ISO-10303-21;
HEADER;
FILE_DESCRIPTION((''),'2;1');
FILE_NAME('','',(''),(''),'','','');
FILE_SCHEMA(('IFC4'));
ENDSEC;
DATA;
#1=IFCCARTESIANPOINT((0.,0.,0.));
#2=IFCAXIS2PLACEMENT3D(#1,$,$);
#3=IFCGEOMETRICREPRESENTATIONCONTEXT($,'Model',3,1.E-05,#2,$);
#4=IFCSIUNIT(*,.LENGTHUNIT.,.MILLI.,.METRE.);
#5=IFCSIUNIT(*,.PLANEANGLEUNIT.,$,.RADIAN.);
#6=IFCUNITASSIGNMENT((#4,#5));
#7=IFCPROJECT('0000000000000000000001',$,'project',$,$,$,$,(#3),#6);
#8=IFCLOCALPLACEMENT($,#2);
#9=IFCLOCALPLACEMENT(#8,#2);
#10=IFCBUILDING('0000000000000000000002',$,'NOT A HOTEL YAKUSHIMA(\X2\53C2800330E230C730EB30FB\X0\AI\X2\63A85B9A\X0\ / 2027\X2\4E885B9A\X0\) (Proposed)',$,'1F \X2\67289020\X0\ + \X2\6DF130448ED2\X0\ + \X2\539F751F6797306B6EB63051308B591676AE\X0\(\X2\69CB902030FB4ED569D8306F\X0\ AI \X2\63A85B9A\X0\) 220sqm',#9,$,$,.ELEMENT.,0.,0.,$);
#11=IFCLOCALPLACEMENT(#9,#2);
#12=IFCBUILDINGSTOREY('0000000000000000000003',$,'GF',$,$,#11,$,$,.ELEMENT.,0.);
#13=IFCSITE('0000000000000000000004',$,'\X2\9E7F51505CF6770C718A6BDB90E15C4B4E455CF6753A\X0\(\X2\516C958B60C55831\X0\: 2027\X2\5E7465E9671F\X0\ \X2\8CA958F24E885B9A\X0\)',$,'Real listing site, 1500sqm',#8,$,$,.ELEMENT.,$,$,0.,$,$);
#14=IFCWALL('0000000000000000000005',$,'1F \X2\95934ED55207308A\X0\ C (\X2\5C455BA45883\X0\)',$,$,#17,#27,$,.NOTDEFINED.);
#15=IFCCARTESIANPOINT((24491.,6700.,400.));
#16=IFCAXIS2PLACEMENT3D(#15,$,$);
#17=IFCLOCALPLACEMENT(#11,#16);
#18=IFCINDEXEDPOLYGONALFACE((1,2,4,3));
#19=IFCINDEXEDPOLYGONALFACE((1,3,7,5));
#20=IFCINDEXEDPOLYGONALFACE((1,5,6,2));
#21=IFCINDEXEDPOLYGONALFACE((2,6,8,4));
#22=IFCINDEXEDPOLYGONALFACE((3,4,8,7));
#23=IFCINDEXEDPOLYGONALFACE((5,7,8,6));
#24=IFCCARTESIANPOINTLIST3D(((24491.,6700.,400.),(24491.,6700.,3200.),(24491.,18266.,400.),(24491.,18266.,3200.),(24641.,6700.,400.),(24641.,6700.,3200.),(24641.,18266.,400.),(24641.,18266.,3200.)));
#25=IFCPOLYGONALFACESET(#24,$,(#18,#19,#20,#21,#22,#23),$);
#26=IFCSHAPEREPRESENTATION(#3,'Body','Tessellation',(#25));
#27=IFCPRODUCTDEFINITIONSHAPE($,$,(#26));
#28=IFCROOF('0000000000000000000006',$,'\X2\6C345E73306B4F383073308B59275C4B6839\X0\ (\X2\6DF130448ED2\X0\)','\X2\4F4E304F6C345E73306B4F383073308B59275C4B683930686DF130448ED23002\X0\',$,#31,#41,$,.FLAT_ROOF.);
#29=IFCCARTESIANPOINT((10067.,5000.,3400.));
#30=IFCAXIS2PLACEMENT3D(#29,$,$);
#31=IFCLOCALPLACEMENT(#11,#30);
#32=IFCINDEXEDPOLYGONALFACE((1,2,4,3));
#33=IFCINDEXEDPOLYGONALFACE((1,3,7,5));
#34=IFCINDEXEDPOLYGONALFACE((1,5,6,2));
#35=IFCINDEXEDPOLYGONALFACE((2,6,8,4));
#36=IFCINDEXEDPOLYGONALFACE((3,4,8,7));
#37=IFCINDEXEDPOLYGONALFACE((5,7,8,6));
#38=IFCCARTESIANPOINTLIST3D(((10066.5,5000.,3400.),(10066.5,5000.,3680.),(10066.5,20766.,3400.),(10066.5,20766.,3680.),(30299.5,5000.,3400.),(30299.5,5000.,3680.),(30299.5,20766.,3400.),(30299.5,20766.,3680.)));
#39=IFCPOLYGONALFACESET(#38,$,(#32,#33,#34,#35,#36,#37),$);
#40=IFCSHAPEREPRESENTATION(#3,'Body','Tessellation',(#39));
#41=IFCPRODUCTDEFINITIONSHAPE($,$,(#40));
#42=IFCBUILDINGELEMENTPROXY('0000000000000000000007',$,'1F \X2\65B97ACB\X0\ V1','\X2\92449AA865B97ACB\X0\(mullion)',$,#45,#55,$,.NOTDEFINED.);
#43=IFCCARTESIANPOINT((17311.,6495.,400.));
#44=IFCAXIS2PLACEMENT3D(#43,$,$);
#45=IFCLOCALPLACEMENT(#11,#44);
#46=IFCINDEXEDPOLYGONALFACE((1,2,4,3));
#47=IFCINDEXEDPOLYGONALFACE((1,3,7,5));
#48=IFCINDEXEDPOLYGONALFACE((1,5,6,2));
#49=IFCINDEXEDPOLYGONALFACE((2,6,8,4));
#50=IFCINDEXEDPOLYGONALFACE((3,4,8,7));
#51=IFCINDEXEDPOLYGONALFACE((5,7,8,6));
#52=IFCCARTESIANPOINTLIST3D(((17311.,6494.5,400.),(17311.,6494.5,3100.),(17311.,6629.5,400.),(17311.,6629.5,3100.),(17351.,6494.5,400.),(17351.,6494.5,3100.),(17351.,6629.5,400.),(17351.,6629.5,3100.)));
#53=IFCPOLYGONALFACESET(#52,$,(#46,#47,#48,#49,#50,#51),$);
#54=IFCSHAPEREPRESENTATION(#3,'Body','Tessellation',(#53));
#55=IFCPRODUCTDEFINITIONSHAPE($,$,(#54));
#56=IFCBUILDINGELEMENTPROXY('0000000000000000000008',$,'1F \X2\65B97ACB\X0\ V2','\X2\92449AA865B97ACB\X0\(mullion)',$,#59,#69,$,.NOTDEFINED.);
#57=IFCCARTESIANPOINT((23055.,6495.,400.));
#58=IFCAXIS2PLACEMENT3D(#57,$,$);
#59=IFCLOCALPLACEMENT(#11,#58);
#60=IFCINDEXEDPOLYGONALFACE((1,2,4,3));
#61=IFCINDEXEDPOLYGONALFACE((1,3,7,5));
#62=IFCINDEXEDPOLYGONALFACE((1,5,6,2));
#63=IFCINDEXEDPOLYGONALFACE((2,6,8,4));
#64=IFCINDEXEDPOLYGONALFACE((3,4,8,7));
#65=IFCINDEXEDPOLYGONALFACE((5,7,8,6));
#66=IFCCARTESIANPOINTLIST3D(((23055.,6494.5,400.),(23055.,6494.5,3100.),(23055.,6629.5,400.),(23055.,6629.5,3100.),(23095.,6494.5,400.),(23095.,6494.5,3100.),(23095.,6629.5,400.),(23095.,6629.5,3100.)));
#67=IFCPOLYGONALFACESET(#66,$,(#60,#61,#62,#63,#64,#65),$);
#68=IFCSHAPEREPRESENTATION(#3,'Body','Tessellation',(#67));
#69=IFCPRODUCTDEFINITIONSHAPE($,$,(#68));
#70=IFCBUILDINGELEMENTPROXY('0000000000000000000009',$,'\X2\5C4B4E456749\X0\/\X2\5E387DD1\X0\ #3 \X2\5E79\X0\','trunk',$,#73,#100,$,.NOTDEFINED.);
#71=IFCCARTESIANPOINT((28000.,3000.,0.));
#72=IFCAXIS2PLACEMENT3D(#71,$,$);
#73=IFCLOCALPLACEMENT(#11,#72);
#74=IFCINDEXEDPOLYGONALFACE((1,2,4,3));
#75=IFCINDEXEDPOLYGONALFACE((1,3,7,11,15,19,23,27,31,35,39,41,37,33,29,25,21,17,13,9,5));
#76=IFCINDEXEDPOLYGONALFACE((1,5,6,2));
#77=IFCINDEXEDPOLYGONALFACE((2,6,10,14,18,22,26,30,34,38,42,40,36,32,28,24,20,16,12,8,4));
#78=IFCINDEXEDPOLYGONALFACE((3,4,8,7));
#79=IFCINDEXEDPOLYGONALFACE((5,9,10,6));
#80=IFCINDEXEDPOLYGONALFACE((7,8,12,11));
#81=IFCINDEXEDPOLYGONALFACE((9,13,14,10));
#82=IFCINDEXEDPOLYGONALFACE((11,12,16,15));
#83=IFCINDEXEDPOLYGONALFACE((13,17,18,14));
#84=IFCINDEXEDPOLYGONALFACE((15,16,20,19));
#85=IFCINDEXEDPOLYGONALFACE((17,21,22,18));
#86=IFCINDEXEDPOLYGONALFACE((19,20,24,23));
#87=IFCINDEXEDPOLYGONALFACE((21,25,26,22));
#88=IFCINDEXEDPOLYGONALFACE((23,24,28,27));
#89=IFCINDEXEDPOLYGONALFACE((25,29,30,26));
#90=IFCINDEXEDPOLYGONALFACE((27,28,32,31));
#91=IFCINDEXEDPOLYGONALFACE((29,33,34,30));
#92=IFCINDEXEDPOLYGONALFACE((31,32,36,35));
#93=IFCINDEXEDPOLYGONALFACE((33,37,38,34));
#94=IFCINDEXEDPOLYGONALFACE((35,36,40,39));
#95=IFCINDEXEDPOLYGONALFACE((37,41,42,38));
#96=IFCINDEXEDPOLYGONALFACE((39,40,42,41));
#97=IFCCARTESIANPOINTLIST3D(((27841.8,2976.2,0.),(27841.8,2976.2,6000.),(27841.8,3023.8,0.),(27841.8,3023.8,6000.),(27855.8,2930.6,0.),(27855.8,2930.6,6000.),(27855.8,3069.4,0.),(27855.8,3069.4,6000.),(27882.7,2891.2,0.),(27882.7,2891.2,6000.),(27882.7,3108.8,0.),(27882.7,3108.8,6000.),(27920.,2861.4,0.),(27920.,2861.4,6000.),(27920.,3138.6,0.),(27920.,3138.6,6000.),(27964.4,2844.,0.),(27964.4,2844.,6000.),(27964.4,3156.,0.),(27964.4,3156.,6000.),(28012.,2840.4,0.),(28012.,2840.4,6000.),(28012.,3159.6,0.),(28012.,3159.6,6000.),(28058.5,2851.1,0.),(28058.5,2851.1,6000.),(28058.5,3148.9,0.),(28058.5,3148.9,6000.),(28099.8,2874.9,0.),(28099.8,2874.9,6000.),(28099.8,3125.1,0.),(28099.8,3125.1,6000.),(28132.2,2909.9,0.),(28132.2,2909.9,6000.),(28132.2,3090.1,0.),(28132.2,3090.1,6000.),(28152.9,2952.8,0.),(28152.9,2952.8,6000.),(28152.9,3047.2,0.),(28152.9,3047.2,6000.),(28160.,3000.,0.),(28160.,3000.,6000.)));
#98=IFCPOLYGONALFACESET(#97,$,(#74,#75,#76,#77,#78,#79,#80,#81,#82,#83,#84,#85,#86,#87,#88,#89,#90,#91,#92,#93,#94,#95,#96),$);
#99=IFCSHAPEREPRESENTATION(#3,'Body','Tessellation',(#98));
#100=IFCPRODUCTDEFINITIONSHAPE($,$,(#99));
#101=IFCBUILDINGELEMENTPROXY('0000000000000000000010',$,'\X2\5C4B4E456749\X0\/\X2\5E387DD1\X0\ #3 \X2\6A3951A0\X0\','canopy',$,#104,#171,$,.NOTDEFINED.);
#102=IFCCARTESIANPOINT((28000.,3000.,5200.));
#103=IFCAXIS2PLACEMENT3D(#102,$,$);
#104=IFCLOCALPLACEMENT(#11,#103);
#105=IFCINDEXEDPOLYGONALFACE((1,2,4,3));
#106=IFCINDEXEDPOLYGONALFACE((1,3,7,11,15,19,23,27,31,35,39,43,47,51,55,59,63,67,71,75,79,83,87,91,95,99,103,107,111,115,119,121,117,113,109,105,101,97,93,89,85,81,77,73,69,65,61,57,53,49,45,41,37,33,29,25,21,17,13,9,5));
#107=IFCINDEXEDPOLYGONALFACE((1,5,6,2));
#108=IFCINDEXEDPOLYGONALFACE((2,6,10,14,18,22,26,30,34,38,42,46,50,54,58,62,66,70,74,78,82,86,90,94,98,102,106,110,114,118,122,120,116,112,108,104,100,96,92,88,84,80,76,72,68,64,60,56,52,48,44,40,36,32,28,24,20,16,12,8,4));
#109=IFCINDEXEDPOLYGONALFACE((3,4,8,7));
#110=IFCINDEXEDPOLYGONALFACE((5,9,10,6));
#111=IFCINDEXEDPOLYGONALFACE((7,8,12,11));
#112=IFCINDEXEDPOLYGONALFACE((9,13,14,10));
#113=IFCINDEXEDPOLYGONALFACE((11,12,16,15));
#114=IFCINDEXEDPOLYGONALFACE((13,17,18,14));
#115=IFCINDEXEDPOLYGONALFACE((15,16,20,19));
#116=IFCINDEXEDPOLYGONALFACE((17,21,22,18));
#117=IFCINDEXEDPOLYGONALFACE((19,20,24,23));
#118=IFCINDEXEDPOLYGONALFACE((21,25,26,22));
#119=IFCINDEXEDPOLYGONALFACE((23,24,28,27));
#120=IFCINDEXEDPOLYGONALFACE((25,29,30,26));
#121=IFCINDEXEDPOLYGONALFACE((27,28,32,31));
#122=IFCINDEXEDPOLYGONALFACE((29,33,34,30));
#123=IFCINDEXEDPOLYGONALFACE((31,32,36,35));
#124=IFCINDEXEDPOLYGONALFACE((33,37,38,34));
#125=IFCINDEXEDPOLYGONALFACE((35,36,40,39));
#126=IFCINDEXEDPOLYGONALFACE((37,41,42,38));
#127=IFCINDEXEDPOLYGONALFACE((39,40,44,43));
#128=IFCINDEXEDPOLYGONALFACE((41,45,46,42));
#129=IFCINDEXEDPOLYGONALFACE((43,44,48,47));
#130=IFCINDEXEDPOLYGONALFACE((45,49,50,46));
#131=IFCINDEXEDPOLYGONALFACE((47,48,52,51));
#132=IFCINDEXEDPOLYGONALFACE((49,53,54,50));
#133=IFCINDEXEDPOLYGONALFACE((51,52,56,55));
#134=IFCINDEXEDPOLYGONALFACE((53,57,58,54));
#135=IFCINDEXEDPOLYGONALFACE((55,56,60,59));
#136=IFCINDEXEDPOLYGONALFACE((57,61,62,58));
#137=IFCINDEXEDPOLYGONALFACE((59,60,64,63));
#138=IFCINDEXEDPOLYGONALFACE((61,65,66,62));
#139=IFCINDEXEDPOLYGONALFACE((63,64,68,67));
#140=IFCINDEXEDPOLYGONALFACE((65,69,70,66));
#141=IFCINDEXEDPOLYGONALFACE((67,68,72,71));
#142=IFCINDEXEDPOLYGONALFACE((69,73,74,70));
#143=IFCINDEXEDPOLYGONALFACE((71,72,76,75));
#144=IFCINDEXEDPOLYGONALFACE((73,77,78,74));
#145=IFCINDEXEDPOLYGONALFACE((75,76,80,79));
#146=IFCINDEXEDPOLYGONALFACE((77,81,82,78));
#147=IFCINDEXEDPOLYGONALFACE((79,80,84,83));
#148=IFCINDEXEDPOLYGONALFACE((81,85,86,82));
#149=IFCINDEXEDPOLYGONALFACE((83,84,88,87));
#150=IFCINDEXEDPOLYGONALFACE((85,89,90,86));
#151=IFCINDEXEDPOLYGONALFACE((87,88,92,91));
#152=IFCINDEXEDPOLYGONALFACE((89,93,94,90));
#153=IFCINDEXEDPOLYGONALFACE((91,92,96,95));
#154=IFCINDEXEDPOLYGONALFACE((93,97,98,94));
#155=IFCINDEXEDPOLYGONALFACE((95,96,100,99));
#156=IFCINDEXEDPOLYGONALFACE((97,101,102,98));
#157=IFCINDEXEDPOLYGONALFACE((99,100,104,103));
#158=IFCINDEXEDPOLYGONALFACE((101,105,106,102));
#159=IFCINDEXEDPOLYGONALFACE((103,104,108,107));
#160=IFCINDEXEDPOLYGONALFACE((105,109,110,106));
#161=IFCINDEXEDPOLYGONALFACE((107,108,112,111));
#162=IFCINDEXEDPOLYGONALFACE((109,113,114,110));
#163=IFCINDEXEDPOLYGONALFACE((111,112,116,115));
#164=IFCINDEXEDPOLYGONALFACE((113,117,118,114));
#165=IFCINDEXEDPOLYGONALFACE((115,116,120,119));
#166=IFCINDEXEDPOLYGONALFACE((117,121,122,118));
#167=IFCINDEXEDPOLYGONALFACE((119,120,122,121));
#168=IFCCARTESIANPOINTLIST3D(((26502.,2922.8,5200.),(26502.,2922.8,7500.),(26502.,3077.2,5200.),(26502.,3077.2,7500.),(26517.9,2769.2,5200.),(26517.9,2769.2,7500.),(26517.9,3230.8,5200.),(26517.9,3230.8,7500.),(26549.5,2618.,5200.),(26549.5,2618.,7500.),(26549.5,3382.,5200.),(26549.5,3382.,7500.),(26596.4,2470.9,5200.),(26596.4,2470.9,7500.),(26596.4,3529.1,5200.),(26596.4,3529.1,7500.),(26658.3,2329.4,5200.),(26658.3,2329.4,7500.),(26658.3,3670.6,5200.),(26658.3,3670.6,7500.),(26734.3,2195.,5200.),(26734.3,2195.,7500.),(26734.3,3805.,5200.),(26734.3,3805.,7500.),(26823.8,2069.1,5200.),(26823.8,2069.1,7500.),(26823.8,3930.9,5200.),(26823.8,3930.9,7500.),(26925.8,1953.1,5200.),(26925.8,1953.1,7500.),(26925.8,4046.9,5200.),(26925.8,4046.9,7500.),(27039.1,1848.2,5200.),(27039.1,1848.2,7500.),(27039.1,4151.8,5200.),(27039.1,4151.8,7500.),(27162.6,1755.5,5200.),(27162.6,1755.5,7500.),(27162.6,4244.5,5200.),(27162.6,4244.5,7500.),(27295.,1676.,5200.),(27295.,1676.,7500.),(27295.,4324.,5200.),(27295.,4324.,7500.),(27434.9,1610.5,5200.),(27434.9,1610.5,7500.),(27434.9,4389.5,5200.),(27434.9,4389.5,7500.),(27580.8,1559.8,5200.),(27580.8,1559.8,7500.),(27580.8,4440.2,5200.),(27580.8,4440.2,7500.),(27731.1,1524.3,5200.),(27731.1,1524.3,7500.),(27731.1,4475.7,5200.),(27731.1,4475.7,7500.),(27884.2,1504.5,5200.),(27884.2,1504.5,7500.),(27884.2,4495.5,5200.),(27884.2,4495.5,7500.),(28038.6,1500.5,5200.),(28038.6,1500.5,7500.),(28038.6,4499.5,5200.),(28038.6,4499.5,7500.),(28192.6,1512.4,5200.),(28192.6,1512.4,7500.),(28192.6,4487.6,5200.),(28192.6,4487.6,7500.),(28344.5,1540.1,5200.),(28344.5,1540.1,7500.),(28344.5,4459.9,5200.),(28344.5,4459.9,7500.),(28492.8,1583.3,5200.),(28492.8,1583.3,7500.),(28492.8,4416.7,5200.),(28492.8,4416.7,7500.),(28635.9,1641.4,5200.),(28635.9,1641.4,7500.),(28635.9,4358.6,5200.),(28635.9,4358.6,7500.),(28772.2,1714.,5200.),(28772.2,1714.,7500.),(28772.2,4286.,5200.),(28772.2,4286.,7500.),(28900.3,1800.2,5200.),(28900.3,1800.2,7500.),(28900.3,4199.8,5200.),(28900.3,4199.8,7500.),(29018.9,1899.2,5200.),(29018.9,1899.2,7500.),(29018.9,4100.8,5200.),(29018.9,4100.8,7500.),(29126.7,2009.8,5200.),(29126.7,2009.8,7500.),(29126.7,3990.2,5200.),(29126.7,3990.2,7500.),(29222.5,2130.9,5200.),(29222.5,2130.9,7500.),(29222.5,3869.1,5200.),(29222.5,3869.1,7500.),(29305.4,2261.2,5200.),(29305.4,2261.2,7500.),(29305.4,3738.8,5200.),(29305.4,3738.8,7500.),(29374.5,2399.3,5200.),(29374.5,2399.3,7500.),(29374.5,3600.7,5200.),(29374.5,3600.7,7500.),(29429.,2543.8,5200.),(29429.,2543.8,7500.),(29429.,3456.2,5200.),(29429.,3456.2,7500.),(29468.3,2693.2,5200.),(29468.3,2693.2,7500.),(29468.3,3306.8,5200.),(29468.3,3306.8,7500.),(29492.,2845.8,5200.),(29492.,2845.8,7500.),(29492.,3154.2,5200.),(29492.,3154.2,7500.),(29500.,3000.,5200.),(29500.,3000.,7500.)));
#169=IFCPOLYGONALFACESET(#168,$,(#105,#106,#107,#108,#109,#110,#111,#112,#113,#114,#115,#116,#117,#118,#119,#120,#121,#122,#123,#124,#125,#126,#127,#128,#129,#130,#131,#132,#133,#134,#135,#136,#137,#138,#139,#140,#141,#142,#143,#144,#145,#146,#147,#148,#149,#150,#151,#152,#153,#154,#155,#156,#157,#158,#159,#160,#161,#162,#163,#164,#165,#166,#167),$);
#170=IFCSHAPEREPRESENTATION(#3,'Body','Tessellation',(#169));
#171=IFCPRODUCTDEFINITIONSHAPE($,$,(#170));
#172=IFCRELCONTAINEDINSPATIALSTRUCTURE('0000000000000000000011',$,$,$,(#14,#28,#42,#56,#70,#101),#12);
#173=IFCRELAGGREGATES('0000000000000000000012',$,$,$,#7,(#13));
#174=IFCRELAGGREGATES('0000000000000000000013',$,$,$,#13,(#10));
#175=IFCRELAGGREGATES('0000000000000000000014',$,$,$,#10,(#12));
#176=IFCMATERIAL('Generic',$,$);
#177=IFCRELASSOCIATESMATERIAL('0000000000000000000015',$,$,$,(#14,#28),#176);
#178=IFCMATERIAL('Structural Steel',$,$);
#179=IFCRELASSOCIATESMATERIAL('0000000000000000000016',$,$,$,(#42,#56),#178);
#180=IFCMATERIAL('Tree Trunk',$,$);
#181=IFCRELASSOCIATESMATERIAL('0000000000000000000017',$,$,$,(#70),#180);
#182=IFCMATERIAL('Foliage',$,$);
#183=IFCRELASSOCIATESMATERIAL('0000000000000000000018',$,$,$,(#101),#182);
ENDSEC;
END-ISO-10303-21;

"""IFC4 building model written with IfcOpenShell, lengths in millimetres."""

from ifc_helpers import new_model, si_unit, frame, frame_2d, origin, origin_2d, place, context, project, spatial, rectangle, circle, extrude, material, element, save


model = new_model("IFC4")

# Units and contexts
model_context = context("Model", 3, precision=1e-05, world=origin())
ifc_project = project(units=[si_unit("LENGTHUNIT", "METRE", prefix="MILLI"), si_unit("PLANEANGLEUNIT", "RADIAN")], contexts=[model_context])

# Site, building, storey
site_placement = place(None, origin())
site = spatial("IfcSite", under=ifc_project, at=site_placement, Name="鹿児島県熊毛郡屋久島町(公開情報: 2027年早期 販売予定)", ObjectType="Real listing site, 1500sqm", CompositionType="ELEMENT", RefElevation=0.0)
building_placement = place(site_placement, origin())
building = spatial("IfcBuilding", under=site, at=building_placement, Name="NOT A HOTEL YAKUSHIMA(参考モデル・AI推定 / 2027予定) (Proposed)", ObjectType="1F 木造 + 深い軒 + 原生林に溶ける外皮(構造・仕様は AI 推定) 220sqm", CompositionType="ELEMENT", ElevationOfRefHeight=0.0, ElevationOfTerrain=0.0)
storey_placement = place(building_placement, origin())
storey = spatial("IfcBuildingStorey", under=building, at=storey_placement, Name="GF", CompositionType="ELEMENT", Elevation=0.0)

# Shared definitions
ifc_material_1 = material(Name="Generic")

# Wall
wall_1_placement = place(storey_placement, frame((24491.0, 6700.0, 400.0)))
element("IfcWall", 1, at=wall_1_placement, inside=storey, material=ifc_material_1, Name="1F 間仕切り C (居室境)", PredefinedType="NOTDEFINED", context=model_context, shape_type="SweptSolid", body=[
    extrude(rectangle(XDim=150.0, YDim=11566.0, at=frame_2d((75.0, 5783.0))), frame((24491.0, 6700.0, 400.0)), (0.0, 0.0, 1.0), 2800.0),
])

# Roof
roof_placement = place(storey_placement, frame((10067.0, 5000.0, 3400.0)))
element("IfcRoof", 2, at=roof_placement, inside=storey, material=ifc_material_1, Name="水平に伸びる大屋根 (深い軒)", Description="低く水平に伸びる大屋根と深い軒。", PredefinedType="FLAT_ROOF", context=model_context, shape_type="SweptSolid", body=[
    extrude(rectangle(XDim=20233.0, YDim=15766.0, at=frame_2d((10116.0, 7883.0))), frame((10067.0, 5000.0, 3400.0)), (0.0, 0.0, 1.0), 280.0),
])

# Building element proxies
ifc_material_2 = material(Name="Structural Steel")
proxy_1_placement = place(storey_placement, frame((17311.0, 6495.0, 400.0)))
element("IfcBuildingElementProxy", 3, at=proxy_1_placement, inside=storey, material=ifc_material_2, Name="1F 方立 V1", Description="鉄骨方立(mullion)", PredefinedType="NOTDEFINED", context=model_context, shape_type="SweptSolid", body=[
    extrude(rectangle(XDim=40.0, YDim=135.0, at=frame_2d((20.0, 67.0))), frame((17311.0, 6495.0, 400.0)), (0.0, 0.0, 1.0), 2700.0),
])
proxy_2_placement = place(storey_placement, frame((23055.0, 6495.0, 400.0)))
element("IfcBuildingElementProxy", 4, at=proxy_2_placement, inside=storey, material=ifc_material_2, Name="1F 方立 V2", Description="鉄骨方立(mullion)", PredefinedType="NOTDEFINED", context=model_context, shape_type="SweptSolid", body=[
    extrude(rectangle(XDim=40.0, YDim=135.0, at=frame_2d((20.0, 67.0))), frame((23055.0, 6495.0, 400.0)), (0.0, 0.0, 1.0), 2700.0),
])
ifc_material_3 = material(Name="Tree Trunk")
proxy_3_placement = place(storey_placement, frame((28000.0, 3000.0, 0.0)))
element("IfcBuildingElementProxy", 5, at=proxy_3_placement, inside=storey, material=ifc_material_3, Name="屋久杉/常緑 #3 幹", Description="trunk", PredefinedType="NOTDEFINED", context=model_context, shape_type="SweptSolid", body=[
    extrude(circle(Radius=160.0, at=origin_2d()), frame((28000.0, 3000.0, 0.0)), (0.0, 0.0, 1.0), 6000.0),
])
ifc_material_4 = material(Name="Foliage")
proxy_4_placement = place(storey_placement, frame((28000.0, 3000.0, 5200.0)))
element("IfcBuildingElementProxy", 6, at=proxy_4_placement, inside=storey, material=ifc_material_4, Name="屋久杉/常緑 #3 樹冠", Description="canopy", PredefinedType="NOTDEFINED", context=model_context, shape_type="SweptSolid", body=[
    extrude(circle(Radius=1500.0, at=origin_2d()), frame((28000.0, 3000.0, 5200.0)), (0.0, 0.0, 1.0), 2300.0),
])

save(model, "model.ifc")
